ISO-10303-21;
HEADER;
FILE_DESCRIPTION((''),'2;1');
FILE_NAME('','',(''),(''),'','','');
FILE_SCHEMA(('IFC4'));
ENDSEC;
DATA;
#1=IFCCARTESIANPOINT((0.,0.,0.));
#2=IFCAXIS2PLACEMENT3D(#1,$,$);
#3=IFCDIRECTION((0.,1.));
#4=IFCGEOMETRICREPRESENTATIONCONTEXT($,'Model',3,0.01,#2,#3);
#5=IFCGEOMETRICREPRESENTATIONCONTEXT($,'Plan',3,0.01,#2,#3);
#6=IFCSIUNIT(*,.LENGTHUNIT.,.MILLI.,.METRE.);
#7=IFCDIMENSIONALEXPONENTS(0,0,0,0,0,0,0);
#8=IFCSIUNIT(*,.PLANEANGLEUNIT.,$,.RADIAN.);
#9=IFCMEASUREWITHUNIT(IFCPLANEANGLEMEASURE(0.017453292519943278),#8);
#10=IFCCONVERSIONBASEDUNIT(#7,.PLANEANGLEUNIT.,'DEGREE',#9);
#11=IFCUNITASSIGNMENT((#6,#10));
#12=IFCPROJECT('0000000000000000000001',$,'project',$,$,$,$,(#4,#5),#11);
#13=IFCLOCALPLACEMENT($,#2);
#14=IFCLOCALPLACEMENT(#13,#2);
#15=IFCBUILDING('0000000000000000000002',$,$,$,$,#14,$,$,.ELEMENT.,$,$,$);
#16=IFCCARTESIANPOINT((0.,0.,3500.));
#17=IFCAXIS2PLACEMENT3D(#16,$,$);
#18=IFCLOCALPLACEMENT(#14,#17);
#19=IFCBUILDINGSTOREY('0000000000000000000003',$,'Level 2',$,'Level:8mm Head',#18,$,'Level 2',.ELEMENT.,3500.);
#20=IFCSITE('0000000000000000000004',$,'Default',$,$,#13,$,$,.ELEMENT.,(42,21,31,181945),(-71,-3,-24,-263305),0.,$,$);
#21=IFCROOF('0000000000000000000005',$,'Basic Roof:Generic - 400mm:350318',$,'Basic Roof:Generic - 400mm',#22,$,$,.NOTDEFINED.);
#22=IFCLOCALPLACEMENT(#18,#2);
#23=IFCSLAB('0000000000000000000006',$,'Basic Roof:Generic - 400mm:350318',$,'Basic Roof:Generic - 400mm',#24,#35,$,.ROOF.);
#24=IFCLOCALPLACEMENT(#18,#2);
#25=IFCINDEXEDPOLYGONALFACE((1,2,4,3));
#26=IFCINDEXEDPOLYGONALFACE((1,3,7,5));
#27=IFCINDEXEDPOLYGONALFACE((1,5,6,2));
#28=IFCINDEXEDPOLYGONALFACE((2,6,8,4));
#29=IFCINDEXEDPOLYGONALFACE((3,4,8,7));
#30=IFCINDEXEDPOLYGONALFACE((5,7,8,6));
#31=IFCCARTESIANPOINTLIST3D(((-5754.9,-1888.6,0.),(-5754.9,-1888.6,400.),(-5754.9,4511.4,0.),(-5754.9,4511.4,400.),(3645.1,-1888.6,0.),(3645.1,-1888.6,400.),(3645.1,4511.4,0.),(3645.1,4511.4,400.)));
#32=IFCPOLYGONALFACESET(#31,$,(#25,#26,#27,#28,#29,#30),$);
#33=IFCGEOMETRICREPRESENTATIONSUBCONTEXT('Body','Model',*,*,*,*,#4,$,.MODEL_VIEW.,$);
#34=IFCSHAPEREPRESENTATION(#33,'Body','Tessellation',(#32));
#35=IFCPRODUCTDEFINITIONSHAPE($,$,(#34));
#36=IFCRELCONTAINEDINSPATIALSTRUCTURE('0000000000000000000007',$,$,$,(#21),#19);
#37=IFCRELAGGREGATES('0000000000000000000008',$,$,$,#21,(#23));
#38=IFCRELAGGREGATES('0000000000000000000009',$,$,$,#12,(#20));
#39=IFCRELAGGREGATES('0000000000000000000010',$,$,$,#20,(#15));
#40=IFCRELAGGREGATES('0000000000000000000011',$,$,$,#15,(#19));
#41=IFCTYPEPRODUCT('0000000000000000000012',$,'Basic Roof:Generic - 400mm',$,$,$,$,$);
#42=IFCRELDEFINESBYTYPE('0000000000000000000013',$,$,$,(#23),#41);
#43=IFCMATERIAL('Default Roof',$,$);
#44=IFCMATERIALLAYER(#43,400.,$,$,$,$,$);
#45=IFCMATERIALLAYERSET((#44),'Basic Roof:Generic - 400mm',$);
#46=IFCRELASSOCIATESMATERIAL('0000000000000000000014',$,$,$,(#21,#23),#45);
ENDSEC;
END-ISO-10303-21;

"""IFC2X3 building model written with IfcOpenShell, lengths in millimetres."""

from ifc_helpers import new_model, entity, si_unit, converted_unit, direction, frame, frame_2d, origin, place, context, subcontext, project, spatial, rectangle, extrude, material, layer, layer_set, type_object, element, aggregate, save


model = new_model("IFC2X3")

# Units and contexts
model_context = context("Model", 3, precision=0.01, world=origin(), true_north=direction((0.0, 1.0)))
plan_context = context("Plan", 3, precision=0.01, world=origin(), true_north=direction((0.0, 1.0)))
body_context = subcontext(model_context, "Body", "Model", "MODEL_VIEW")
ifc_project = project(units=[si_unit("LENGTHUNIT", "METRE", prefix="MILLI"), converted_unit("PLANEANGLEUNIT", "DEGREE", entity("IfcPlaneAngleMeasure", 0.017453292519943278), si_unit("PLANEANGLEUNIT", "RADIAN"), dimensions=[0, 0, 0, 0, 0, 0, 0])], contexts=[model_context, plan_context])

# Site, building, storey
site_placement = place(None, origin())
site = spatial("IfcSite", under=ifc_project, at=site_placement, Name="Default", CompositionType="ELEMENT", RefLatitude=(42, 21, 31, 181945), RefLongitude=(-71, -3, -24, -263305), RefElevation=0.0)
building_placement = place(site_placement, origin())
building = spatial("IfcBuilding", under=site, at=building_placement, CompositionType="ELEMENT")
storey_placement = place(building_placement, frame((0.0, 0.0, 3500.0)))
storey = spatial("IfcBuildingStorey", under=building, at=storey_placement, Name="Level 2", ObjectType="Level:8mm Head", LongName="Level 2", CompositionType="ELEMENT", Elevation=3500.0)

# Roof, slab
ifc_material = material(Name="Default Roof")
ifc_layer = layer(ifc_material, 400.0)
ifc_layer_set = layer_set([ifc_layer], Name="Basic Roof:Generic - 400mm")
roof_placement = place(storey_placement, frame((-5754.9, -1888.6, 0.0)))
roof = element("IfcRoof", 1, at=roof_placement, inside=storey, material=ifc_layer_set, Name="Basic Roof:Generic - 400mm:350318", ObjectType="Basic Roof:Generic - 400mm", ShapeType="NOTDEFINED")
type_product = type_object("IfcTypeProduct", Name="Basic Roof:Generic - 400mm")
slab_placement = place(roof_placement, origin())
slab = element("IfcSlab", 2, at=slab_placement, type_object=type_product, material=ifc_layer_set, Name="Basic Roof:Generic - 400mm:350318", ObjectType="Basic Roof:Generic - 400mm", PredefinedType="ROOF", context=body_context, shape_type="SweptSolid", body=[
    extrude(rectangle(XDim=9400.0, YDim=6400.0, at=frame_2d((0.0, 0.0), x_axis=(1.0, 0.0))), frame((4700.0, 3200.0, 0.0)), (0.0, 0.0, 1.0), 400.0),
])
aggregate(roof, [slab])

save(model, "model.ifc")
